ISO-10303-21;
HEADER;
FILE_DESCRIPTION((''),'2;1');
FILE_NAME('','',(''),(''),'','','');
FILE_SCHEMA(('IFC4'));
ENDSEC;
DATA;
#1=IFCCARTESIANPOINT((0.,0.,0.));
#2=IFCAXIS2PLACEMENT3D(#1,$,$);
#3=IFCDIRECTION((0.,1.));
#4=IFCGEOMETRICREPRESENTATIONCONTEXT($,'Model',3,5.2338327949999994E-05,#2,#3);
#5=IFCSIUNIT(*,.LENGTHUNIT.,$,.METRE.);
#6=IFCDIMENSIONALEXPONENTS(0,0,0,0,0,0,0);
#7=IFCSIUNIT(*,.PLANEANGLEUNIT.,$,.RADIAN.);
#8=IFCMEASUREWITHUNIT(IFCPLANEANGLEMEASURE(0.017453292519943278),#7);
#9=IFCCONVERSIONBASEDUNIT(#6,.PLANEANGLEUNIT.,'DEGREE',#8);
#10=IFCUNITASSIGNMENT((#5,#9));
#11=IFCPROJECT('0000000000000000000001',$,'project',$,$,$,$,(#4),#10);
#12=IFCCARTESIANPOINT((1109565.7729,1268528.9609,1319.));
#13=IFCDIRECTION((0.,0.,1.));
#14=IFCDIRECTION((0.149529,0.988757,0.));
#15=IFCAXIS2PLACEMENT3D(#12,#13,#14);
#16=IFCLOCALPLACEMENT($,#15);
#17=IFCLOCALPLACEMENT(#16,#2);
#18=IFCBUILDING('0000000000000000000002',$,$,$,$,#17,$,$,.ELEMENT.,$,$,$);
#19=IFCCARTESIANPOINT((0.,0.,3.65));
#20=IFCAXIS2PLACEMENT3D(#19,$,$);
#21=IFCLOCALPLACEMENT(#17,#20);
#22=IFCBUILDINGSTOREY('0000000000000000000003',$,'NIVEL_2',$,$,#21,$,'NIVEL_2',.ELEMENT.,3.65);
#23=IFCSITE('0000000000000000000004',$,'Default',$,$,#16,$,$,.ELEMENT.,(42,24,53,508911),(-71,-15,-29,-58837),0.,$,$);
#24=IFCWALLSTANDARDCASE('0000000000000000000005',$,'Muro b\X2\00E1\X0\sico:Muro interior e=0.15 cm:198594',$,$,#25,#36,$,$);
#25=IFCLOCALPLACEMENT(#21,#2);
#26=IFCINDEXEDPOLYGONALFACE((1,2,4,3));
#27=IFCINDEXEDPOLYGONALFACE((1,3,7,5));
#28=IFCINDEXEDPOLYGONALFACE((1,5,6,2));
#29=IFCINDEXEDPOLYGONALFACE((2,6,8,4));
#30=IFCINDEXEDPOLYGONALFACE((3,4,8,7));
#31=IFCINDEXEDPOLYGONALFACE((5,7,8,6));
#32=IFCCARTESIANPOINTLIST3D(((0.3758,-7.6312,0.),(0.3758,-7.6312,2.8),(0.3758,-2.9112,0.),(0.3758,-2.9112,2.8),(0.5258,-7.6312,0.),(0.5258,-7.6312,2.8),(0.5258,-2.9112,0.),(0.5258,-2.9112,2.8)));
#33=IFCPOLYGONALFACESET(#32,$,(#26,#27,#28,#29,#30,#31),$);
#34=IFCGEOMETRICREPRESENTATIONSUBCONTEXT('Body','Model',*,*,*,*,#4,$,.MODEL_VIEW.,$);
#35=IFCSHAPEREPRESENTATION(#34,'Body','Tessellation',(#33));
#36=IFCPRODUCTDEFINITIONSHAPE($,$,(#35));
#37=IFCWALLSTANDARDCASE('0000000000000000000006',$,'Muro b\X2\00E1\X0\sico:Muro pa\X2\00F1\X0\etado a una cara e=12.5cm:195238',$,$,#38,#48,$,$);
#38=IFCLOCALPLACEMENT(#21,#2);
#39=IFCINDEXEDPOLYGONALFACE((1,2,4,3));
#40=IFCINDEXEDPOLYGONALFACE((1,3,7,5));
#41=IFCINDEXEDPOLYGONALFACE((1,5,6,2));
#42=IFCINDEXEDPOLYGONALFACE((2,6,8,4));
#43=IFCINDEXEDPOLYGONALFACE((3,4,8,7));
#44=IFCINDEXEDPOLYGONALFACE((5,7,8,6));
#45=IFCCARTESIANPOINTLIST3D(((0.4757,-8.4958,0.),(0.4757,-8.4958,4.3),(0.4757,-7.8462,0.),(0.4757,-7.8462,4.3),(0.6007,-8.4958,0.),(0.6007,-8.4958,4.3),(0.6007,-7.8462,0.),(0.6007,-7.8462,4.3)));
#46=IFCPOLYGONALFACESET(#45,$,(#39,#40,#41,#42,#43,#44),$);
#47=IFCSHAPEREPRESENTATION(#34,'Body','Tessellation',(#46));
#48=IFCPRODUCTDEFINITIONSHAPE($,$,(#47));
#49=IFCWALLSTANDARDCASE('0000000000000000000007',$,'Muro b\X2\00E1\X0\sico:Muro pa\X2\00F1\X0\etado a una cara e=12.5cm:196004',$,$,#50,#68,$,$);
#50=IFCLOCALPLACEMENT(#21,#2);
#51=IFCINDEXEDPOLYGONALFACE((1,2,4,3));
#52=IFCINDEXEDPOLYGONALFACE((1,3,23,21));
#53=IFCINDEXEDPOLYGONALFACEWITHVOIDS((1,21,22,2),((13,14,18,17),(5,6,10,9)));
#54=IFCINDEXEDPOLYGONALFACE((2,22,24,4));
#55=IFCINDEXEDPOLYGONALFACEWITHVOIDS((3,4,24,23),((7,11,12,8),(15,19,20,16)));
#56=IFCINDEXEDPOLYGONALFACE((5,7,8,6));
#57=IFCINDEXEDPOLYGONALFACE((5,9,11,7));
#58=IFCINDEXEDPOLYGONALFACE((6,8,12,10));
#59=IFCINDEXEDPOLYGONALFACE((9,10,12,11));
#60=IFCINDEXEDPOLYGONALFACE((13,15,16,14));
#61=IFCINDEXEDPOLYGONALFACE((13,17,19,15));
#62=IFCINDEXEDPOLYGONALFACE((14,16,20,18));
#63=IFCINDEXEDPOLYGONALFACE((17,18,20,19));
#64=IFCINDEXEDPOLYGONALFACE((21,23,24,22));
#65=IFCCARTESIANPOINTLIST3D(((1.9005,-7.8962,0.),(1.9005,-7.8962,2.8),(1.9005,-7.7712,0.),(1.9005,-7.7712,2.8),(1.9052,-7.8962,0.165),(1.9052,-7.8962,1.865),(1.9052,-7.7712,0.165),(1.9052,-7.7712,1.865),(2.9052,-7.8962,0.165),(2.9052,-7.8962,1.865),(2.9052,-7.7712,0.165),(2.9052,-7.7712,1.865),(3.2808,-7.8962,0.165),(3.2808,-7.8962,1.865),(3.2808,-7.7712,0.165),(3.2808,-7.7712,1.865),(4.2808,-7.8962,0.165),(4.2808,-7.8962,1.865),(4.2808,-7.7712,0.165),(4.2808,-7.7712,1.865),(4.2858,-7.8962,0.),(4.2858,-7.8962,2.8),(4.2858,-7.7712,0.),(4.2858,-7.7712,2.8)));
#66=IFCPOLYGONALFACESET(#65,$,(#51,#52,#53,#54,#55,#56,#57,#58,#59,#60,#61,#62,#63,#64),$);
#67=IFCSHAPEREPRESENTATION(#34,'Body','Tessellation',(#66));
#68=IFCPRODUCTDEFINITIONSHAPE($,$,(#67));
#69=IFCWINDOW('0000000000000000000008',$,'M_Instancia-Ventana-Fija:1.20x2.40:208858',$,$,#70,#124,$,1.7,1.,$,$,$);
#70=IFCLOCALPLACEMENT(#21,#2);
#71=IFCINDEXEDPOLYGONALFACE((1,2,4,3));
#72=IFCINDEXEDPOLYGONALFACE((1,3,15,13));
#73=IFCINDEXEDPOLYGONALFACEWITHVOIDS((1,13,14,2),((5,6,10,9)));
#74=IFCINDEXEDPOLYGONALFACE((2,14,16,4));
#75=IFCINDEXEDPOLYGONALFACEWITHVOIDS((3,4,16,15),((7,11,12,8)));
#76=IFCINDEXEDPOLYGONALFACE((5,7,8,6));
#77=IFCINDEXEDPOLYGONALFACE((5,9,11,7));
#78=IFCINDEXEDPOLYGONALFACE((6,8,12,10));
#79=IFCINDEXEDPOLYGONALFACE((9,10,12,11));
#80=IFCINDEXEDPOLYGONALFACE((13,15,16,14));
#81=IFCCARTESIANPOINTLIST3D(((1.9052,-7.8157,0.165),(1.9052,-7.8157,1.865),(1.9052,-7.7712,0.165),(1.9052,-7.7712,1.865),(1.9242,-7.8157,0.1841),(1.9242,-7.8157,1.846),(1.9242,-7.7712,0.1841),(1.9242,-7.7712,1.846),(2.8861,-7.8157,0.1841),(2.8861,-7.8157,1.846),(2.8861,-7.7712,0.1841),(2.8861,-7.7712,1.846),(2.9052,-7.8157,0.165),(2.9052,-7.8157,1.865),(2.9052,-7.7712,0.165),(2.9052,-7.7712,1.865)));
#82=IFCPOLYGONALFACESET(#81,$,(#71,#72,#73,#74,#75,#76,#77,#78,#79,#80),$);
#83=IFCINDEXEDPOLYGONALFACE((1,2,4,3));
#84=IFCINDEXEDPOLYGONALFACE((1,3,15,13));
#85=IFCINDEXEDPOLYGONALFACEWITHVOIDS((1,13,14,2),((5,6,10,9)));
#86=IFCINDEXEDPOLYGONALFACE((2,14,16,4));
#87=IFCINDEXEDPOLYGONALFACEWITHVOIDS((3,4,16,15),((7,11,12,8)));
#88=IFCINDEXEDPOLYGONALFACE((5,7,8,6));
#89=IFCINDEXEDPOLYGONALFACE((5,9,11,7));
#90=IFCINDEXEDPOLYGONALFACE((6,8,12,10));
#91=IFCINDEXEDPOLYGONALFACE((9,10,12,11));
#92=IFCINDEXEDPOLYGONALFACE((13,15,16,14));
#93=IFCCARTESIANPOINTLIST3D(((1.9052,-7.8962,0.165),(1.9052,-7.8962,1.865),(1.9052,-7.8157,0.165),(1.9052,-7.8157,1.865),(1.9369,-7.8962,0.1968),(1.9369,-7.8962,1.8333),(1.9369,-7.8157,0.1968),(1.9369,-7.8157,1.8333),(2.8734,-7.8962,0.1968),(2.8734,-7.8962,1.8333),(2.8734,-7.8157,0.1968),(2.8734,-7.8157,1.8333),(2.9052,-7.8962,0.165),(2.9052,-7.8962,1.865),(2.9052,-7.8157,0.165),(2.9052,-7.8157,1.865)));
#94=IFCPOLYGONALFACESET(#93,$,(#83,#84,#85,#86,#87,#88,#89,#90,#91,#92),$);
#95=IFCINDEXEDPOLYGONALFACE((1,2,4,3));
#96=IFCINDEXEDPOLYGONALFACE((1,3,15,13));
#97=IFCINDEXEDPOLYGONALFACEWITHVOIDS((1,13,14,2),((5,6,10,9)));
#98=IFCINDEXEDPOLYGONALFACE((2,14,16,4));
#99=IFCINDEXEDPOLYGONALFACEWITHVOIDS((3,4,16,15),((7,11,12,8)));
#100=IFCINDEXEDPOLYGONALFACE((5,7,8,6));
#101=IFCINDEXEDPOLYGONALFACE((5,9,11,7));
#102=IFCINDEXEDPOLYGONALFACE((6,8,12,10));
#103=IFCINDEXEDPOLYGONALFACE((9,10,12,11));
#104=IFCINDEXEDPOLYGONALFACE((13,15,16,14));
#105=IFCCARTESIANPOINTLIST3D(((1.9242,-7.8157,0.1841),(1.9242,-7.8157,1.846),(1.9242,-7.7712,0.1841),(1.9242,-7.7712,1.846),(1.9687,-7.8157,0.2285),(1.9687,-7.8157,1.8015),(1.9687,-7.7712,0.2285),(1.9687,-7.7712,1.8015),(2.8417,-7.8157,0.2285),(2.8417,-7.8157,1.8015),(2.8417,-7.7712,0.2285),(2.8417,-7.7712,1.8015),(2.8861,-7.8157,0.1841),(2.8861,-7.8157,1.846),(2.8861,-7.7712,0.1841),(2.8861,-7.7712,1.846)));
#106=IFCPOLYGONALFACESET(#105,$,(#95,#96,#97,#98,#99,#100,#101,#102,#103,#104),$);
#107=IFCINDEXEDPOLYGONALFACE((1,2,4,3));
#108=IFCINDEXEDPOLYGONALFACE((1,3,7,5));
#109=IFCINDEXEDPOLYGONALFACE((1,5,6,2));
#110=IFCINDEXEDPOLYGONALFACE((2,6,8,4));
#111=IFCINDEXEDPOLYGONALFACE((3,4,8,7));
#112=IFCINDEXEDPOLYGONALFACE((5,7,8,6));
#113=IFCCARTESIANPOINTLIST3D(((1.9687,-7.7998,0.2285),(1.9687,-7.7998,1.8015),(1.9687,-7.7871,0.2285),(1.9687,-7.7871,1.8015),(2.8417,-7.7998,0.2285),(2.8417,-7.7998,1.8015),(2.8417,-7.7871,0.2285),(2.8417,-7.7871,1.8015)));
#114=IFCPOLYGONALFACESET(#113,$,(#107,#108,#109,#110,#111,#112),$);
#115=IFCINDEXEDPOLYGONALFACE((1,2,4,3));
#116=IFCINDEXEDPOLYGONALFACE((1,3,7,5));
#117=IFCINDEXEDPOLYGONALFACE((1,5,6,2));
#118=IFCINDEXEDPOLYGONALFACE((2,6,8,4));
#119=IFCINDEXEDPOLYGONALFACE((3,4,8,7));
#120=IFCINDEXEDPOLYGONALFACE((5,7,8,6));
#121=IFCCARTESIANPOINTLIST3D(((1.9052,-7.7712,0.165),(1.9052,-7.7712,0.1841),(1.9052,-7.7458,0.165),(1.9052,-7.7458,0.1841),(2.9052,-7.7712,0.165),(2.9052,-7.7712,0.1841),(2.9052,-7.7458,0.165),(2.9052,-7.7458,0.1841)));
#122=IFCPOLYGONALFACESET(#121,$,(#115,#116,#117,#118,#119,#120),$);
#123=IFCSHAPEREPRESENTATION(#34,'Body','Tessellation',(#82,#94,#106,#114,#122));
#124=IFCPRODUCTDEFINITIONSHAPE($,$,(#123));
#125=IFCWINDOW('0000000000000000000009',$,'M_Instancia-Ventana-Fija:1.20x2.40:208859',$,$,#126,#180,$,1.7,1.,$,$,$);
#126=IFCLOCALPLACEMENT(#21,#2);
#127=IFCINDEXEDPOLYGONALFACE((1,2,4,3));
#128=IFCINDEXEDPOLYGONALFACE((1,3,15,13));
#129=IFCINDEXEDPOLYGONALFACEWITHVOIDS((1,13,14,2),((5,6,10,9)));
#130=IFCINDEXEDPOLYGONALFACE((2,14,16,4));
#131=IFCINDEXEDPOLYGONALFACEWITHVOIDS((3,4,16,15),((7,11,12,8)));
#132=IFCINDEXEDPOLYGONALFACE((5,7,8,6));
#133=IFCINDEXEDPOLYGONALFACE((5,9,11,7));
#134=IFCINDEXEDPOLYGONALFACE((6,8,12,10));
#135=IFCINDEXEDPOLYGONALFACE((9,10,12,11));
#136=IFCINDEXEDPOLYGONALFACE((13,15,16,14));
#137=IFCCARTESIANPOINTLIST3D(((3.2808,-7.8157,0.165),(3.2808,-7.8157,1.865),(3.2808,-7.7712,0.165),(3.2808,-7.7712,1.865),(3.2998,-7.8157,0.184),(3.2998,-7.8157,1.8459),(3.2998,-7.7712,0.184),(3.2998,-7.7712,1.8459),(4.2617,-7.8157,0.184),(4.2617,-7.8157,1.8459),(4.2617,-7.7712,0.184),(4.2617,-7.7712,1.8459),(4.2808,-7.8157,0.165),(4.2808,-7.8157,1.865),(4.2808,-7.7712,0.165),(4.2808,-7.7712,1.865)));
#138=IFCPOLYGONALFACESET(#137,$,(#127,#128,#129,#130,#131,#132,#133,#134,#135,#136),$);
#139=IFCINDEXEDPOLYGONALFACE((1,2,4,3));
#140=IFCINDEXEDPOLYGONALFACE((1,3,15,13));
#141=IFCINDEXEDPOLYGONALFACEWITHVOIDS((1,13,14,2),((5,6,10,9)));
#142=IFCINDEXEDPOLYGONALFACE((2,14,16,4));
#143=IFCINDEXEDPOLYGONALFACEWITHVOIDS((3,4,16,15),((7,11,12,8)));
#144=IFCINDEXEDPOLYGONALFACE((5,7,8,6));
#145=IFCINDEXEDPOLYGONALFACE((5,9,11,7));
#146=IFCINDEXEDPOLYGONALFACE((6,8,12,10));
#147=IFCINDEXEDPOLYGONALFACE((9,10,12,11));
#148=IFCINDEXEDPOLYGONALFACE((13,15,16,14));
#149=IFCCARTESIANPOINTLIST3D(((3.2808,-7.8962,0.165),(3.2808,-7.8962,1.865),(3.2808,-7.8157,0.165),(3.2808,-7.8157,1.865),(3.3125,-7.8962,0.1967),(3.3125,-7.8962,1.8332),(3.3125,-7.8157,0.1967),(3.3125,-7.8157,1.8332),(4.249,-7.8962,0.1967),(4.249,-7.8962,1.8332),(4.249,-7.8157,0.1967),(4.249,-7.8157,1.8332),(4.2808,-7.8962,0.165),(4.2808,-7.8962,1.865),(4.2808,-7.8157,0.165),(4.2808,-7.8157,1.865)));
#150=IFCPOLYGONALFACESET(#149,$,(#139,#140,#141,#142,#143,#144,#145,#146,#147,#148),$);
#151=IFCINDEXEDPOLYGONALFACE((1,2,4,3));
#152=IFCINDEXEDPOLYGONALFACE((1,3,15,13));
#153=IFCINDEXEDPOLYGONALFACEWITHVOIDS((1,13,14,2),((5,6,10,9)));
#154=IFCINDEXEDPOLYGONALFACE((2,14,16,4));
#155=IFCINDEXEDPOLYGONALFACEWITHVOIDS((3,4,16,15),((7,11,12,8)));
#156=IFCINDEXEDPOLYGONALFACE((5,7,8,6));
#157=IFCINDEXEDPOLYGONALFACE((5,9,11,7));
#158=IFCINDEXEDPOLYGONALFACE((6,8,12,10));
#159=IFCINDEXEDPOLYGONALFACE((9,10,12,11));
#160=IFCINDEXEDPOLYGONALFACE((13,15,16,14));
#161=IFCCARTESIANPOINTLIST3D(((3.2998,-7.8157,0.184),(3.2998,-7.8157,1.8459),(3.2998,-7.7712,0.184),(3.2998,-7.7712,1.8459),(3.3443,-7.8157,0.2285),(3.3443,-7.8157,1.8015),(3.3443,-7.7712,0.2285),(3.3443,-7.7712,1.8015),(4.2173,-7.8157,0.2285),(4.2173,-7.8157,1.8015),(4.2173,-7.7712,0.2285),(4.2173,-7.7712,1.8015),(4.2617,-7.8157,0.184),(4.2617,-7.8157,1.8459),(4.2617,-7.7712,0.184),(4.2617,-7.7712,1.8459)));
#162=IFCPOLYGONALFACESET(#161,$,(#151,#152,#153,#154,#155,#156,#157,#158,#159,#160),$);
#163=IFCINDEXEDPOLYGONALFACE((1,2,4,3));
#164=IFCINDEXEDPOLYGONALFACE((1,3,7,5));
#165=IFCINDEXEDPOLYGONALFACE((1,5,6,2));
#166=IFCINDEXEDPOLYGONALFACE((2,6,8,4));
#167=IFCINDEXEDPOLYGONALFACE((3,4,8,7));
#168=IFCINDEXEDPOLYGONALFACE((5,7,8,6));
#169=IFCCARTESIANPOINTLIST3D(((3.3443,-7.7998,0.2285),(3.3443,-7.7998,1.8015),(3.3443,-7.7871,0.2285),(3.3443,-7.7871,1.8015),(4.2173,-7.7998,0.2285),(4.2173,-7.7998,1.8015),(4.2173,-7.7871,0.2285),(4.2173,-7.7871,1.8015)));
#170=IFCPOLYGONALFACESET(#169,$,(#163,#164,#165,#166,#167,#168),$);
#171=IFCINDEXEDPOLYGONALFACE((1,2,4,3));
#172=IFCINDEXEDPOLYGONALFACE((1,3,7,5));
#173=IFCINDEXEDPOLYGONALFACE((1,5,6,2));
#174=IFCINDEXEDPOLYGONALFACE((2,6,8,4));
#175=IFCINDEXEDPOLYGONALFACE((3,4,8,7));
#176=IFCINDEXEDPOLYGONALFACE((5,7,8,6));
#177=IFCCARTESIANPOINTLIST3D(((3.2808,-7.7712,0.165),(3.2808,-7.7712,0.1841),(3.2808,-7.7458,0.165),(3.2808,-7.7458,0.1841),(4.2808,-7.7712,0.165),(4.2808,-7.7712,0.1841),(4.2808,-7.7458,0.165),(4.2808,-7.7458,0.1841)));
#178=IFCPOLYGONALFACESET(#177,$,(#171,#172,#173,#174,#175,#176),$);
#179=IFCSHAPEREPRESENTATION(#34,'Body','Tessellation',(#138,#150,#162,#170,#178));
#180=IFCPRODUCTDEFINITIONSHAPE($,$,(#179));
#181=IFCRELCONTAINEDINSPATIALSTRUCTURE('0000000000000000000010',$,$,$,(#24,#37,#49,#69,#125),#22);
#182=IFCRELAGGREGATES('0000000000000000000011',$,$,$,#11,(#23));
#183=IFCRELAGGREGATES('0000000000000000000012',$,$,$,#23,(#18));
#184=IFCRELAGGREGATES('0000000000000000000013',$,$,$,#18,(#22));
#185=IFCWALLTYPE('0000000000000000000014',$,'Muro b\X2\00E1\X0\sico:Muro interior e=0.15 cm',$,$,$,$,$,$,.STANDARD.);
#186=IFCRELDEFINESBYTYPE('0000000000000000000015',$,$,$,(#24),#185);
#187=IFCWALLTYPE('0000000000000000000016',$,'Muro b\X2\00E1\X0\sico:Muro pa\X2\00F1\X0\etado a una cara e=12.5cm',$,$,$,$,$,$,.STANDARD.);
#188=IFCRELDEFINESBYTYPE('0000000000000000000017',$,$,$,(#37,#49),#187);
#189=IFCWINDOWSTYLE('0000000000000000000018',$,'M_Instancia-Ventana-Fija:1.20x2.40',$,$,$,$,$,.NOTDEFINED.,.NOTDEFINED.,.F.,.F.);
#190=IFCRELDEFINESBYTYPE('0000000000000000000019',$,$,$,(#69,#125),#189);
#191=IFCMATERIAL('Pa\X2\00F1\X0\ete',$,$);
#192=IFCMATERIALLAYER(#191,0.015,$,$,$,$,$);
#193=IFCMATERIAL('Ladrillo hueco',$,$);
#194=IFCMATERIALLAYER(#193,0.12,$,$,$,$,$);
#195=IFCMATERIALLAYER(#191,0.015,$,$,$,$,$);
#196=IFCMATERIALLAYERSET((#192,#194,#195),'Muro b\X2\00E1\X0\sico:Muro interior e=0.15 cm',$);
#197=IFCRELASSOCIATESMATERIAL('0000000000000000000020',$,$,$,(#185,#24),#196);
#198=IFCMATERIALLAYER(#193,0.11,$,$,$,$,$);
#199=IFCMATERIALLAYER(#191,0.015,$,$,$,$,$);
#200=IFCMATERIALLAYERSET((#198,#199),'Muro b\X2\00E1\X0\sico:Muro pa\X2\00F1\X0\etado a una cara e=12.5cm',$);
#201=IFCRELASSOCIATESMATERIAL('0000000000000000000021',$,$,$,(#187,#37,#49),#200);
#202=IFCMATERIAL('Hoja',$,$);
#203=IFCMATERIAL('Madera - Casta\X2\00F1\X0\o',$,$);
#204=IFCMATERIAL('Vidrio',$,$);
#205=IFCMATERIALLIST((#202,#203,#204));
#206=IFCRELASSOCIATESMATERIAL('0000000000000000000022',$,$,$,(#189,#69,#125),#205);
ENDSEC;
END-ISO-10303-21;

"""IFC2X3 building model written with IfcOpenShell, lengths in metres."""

from ifc_helpers import new_model, entity, si_unit, converted_unit, direction, frame, frame_2d, origin, origin_2d_with_axis, place, context, subcontext, project, spatial, polyline, rectangle, outline, extrude, source, transform, mapped, material, material_list, layer, layer_set, layer_usage, type_object, type_shapes, element, fill, save


model = new_model("IFC2X3")

# Units and contexts
model_context = context("Model", 3, precision=5.2338327949999994e-05, world=origin(), true_north=direction((0.0, 1.0)))
body_context = subcontext(model_context, "Body", "Model", "MODEL_VIEW")
ifc_project = project(units=[si_unit("LENGTHUNIT", "METRE"), converted_unit("PLANEANGLEUNIT", "DEGREE", entity("IfcPlaneAngleMeasure", 0.017453292519943278), si_unit("PLANEANGLEUNIT", "RADIAN"), dimensions=[0, 0, 0, 0, 0, 0, 0])], contexts=[model_context])

# Site, building, storey
site_placement = place(None, frame((1109565.7729, 1268528.9609, 1319.0), z_axis=(0.0, 0.0, 1.0), x_axis=(0.149529, 0.988757, 0.0)))
site = spatial("IfcSite", under=ifc_project, at=site_placement, Name="Default", CompositionType="ELEMENT", RefLatitude=(42, 24, 53, 508911), RefLongitude=(-71, -15, -29, -58837), RefElevation=0.0)
building_placement = place(site_placement, origin())
building = spatial("IfcBuilding", under=site, at=building_placement, CompositionType="ELEMENT")
storey_placement = place(building_placement, frame((0.0, 0.0, 3.65)))
storey = spatial("IfcBuildingStorey", under=building, at=storey_placement, Name="NIVEL_2", LongName="NIVEL_2", CompositionType="ELEMENT", Elevation=3.65)

# Walls
ifc_material_1 = material(Name="Pañete")
ifc_layer_1 = layer(ifc_material_1, 0.015)
ifc_material_2 = material(Name="Ladrillo hueco")
ifc_layer_2 = layer(ifc_material_2, 0.12)
ifc_layer_3 = layer(ifc_material_1, 0.015)
ifc_layer_set_1 = layer_set([ifc_layer_1, ifc_layer_2, ifc_layer_3], Name="Muro básico:Muro interior e=0.15 cm")
ifc_layer_usage_1 = layer_usage(ifc_layer_set_1, "AXIS2", "NEGATIVE", 0.075)
wall_type_1 = type_object("IfcWallType", Name="Muro básico:Muro interior e=0.15 cm", PredefinedType="STANDARD", material=ifc_layer_set_1)
wall_1_placement = place(storey_placement, frame((0.4508, -7.6312, 0.0), z_axis=(0.0, 0.0, 1.0), x_axis=(0.0, 1.0, 0.0)))
element("IfcWallStandardCase", 1, at=wall_1_placement, inside=storey, type_object=wall_type_1, material=ifc_layer_usage_1, Name="Muro básico:Muro interior e=0.15 cm:198594", context=body_context, shape_type="SweptSolid", body=[
    extrude(rectangle(XDim=4.72, YDim=0.15, at=frame_2d((2.36, 0.0), x_axis=(-1.0, 0.0))), origin(), (0.0, 0.0, 1.0), 2.8),
])
ifc_layer_4 = layer(ifc_material_2, 0.11)
ifc_layer_5 = layer(ifc_material_1, 0.015)
ifc_layer_set_2 = layer_set([ifc_layer_4, ifc_layer_5], Name="Muro básico:Muro pañetado a una cara e=12.5cm")
ifc_layer_usage_2 = layer_usage(ifc_layer_set_2, "AXIS2", "POSITIVE", -0.0625)
wall_type_2 = type_object("IfcWallType", Name="Muro básico:Muro pañetado a una cara e=12.5cm", PredefinedType="STANDARD", material=ifc_layer_set_2)
wall_2_placement = place(storey_placement, frame((0.5382, -8.4958, 0.0), z_axis=(0.0, 0.0, 1.0), x_axis=(0.0, 1.0, 0.0)))
element("IfcWallStandardCase", 2, at=wall_2_placement, inside=storey, type_object=wall_type_2, material=ifc_layer_usage_2, Name="Muro básico:Muro pañetado a una cara e=12.5cm:195238", context=body_context, shape_type="SweptSolid", body=[
    extrude(rectangle(XDim=0.6496, YDim=0.125, at=frame_2d((0.3248, 0.0), x_axis=(-1.0, 0.0))), origin(), (0.0, 0.0, 1.0), 4.3),
])

# Wall, openings, windows
ifc_layer_usage_3 = layer_usage(ifc_layer_set_2, "AXIS2", "POSITIVE", -0.0625)
wall_3_placement = place(storey_placement, frame((1.9005, -7.8337, 0.0)))
wall_3 = element("IfcWallStandardCase", 3, at=wall_3_placement, inside=storey, type_object=wall_type_2, material=ifc_layer_usage_3, Name="Muro básico:Muro pañetado a una cara e=12.5cm:196004", context=body_context, shape_type="SweptSolid", body=[
    extrude(rectangle(XDim=2.3853, YDim=0.125, at=frame_2d((1.1927, 0.0), x_axis=(-1.0, 0.0))), origin(), (0.0, 0.0, 1.0), 2.8),
])
opening_1_placement = place(wall_3_placement, frame((1.3803, -0.0625, 0.165)))
opening_1 = element("IfcOpeningElement", 4, at=opening_1_placement, cuts=wall_3, ObjectType="Opening", context=body_context, shape_type="SweptSolid", body=[
    extrude(rectangle(XDim=1.7, YDim=1.0, at=frame_2d((0.85, 0.5), x_axis=(-1.0, 0.0))), frame((0.0, 0.0, 0.0), z_axis=(0.0, 1.0, 0.0), x_axis=(0.0, 0.0, 1.0)), (0.0, 0.0, 1.0), 0.125),
])
opening_2_placement = place(wall_3_placement, frame((0.0047, -0.0625, 0.165)))
opening_2 = element("IfcOpeningElement", 5, at=opening_2_placement, cuts=wall_3, ObjectType="Opening", context=body_context, shape_type="SweptSolid", body=[
    extrude(rectangle(XDim=1.7, YDim=1.0, at=frame_2d((0.85, 0.5), x_axis=(-1.0, 0.0))), frame((0.0, 0.0, 0.0), z_axis=(0.0, 1.0, 0.0), x_axis=(0.0, 0.0, 1.0)), (0.0, 0.0, 1.0), 0.125),
])
ifc_material_3 = material(Name="Hoja")
ifc_material_4 = material(Name="Madera - Castaño")
ifc_material_5 = material(Name="Vidrio")
ifc_material_list = material_list([ifc_material_3, ifc_material_4, ifc_material_5])
window_style = type_object("IfcWindowStyle", Name="M_Instancia-Ventana-Fija:1.20x2.40", ConstructionType="NOTDEFINED", OperationType="NOTDEFINED", ParameterTakesPrecedence=False, Sizeable=False, material=ifc_material_list)
shared_shape = source(origin(), body_context, "Body", "SweptSolid", [
    extrude(outline(polyline([(-0.85, -0.5), (0.85, -0.5), (0.85, 0.5), (-0.85, 0.5), (-0.85, -0.5)]), holes=[polyline([(-0.8309, -0.4809), (-0.8309, 0.481), (0.831, 0.481), (0.831, -0.4809), (-0.8309, -0.4809)])]), frame((0.5, 0.0806, 0.85), z_axis=(0.0, 1.0, 0.0), x_axis=(0.0, 0.0, -1.0)), (0.0, 0.0, 1.0), 0.0444),
    extrude(outline(polyline([(-0.5, -0.85), (0.5, -0.85), (0.5, 0.85), (-0.5, 0.85), (-0.5, -0.85)]), holes=[polyline([(-0.4683, -0.8182), (-0.4683, 0.8183), (0.4682, 0.8183), (0.4682, -0.8182), (-0.4683, -0.8182)])]), frame((0.5, 0.0, 0.85), z_axis=(0.0, 1.0, 0.0), x_axis=(1.0, 0.0, 0.0)), (0.0, 0.0, 1.0), 0.0806),
    extrude(outline(polyline([(-0.4809, -0.831), (0.4809, -0.831), (0.4809, 0.831), (-0.4809, 0.831), (-0.4809, -0.831)]), holes=[polyline([(-0.4365, -0.7865), (-0.4365, 0.7865), (0.4365, 0.7865), (0.4365, -0.7865), (-0.4365, -0.7865)])]), frame((0.5, 0.0806, 0.85), z_axis=(0.0, 1.0, 0.0), x_axis=(1.0, 0.0, 0.0)), (0.0, 0.0, 1.0), 0.0444),
    extrude(rectangle(XDim=0.0127, YDim=0.873, at=frame_2d((0.0, 0.0), x_axis=(1.0, 0.0))), frame((0.5, 0.1028, 0.0635), z_axis=(0.0, 0.0, 1.0), x_axis=(0.0, 1.0, 0.0)), (0.0, 0.0, 1.0), 1.573),
    extrude(rectangle(XDim=0.0254, YDim=1.0, at=origin_2d_with_axis()), frame((0.5, 0.1377, 0.0), z_axis=(0.0, 0.0, 1.0), x_axis=(0.0, -1.0, 0.0)), (0.0, 0.0, 1.0), 0.019),
])
type_shapes(window_style, [shared_shape])
window_1_placement = place(opening_2_placement, origin())
window_1 = element("IfcWindow", 6, at=window_1_placement, inside=storey, type_object=window_style, material=ifc_material_list, Name="M_Instancia-Ventana-Fija:1.20x2.40:208858", OverallHeight=1.7, OverallWidth=1.0, context=body_context, shape_type="MappedRepresentation", body=[
    mapped(shared_shape, transform((0.0, 0.0, 0.0), scale=1.0)),
])
fill(opening_2, window_1)
window_2_placement = place(opening_1_placement, origin())
window_2 = element("IfcWindow", 7, at=window_2_placement, inside=storey, type_object=window_style, material=ifc_material_list, Name="M_Instancia-Ventana-Fija:1.20x2.40:208859", OverallHeight=1.7, OverallWidth=1.0, context=body_context, shape_type="MappedRepresentation", body=[
    mapped(shared_shape, transform((0.0, 0.0, 0.0), scale=1.0)),
])
fill(opening_1, window_2)

save(model, "model.ifc")
